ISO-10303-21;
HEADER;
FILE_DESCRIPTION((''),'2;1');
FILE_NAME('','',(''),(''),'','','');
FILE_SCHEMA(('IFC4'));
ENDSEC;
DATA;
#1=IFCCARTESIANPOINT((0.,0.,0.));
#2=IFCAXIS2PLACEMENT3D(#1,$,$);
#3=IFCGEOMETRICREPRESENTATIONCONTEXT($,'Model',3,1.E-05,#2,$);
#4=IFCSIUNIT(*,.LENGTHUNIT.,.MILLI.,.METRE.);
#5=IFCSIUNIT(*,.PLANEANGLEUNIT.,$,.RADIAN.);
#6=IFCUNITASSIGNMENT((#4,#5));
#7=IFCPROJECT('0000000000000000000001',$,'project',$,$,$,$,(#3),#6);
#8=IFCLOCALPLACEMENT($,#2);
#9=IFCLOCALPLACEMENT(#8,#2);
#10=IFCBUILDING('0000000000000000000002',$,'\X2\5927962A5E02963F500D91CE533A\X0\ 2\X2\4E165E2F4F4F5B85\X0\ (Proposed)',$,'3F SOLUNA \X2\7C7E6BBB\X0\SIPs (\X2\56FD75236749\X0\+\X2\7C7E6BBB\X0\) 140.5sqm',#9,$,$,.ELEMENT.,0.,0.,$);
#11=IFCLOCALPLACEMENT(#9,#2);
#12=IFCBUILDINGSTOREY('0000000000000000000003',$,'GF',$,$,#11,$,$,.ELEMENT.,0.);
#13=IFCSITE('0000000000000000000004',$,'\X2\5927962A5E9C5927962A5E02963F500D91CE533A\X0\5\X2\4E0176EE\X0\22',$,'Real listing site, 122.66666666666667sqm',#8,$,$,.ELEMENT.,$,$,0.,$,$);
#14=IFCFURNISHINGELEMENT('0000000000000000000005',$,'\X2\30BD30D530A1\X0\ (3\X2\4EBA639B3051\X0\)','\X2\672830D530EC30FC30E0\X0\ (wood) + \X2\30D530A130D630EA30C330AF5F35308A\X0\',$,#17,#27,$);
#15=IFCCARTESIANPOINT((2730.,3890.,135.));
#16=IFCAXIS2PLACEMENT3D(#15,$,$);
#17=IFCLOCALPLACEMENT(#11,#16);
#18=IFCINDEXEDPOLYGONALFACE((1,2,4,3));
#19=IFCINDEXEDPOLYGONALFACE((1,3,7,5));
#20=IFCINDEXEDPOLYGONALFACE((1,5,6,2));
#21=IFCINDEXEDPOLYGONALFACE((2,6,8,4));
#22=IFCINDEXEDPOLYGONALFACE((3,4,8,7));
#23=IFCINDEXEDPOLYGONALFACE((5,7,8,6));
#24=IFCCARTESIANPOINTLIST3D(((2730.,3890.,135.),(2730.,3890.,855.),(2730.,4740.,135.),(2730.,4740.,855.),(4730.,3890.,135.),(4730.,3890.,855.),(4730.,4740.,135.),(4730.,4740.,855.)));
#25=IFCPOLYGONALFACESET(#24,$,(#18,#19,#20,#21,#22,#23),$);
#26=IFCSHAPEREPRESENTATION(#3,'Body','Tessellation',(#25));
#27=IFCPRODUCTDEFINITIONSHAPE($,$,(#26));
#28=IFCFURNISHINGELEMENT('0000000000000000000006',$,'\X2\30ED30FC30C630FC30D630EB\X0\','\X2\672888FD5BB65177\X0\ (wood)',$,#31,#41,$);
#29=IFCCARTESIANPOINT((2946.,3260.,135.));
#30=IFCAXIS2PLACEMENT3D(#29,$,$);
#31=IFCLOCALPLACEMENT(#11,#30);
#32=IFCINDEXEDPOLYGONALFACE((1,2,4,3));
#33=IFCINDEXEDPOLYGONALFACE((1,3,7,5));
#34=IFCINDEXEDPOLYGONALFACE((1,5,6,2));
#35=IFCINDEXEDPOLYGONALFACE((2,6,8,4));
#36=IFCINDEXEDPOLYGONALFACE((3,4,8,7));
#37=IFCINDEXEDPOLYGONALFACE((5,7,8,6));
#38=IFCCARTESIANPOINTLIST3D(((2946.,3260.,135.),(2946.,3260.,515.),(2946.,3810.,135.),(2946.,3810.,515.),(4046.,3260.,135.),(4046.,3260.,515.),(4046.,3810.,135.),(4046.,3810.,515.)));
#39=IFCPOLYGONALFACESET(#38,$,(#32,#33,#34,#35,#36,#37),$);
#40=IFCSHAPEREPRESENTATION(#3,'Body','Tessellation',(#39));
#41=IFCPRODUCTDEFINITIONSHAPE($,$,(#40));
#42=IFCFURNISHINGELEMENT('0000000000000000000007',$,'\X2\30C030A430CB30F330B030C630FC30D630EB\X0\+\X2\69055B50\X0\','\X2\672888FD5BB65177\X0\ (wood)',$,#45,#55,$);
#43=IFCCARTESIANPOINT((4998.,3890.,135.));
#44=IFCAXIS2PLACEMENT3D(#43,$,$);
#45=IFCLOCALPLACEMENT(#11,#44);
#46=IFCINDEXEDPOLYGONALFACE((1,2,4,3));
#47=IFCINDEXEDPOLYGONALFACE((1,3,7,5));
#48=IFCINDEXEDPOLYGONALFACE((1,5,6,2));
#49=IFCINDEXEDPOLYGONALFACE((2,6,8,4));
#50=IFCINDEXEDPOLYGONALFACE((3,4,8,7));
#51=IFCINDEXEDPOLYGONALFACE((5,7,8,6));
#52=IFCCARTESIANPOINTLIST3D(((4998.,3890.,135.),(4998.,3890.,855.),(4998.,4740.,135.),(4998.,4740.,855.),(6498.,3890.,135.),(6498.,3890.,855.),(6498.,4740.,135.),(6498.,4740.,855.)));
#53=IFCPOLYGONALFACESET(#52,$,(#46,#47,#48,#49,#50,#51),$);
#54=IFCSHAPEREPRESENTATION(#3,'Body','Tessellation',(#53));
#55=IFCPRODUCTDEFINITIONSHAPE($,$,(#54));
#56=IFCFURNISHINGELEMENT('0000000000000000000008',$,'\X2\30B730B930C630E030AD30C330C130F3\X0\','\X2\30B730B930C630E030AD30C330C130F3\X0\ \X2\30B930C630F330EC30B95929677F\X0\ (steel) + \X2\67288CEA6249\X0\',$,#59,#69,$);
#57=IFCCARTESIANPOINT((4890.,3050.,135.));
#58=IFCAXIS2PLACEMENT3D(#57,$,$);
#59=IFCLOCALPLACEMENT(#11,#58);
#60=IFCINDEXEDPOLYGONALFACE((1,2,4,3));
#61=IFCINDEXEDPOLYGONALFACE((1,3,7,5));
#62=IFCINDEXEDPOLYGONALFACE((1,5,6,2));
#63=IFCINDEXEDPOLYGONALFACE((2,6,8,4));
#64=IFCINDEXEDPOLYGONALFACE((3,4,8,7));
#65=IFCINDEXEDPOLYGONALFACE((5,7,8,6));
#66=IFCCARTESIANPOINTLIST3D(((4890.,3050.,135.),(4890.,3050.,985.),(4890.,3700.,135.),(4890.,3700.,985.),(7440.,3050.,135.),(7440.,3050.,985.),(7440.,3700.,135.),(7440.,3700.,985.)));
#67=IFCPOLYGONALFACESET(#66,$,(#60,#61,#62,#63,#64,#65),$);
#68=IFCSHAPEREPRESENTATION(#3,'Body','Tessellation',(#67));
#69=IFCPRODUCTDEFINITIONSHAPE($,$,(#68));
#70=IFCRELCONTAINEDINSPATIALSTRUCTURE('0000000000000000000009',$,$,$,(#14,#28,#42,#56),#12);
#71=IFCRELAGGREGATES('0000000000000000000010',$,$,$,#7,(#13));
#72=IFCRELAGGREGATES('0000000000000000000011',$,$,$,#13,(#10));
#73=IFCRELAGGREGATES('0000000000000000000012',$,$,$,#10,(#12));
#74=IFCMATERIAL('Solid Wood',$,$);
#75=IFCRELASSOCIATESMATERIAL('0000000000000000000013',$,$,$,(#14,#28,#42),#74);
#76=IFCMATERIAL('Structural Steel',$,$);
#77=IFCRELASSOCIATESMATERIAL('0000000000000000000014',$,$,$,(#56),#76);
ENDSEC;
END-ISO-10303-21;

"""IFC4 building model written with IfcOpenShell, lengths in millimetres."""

from ifc_helpers import new_model, si_unit, frame, frame_2d, origin, place, context, project, spatial, rectangle, extrude, material, element, save


model = new_model("IFC4")

# Units and contexts
model_context = context("Model", 3, precision=1e-05, world=origin())
ifc_project = project(units=[si_unit("LENGTHUNIT", "METRE", prefix="MILLI"), si_unit("PLANEANGLEUNIT", "RADIAN")], contexts=[model_context])

# Site, building, storey
site_placement = place(None, origin())
site = spatial("IfcSite", under=ifc_project, at=site_placement, Name="大阪府大阪市阿倍野区5丁目22", ObjectType="Real listing site, 122.66666666666667sqm", CompositionType="ELEMENT", RefElevation=0.0)
building_placement = place(site_placement, origin())
building = spatial("IfcBuilding", under=site, at=building_placement, Name="大阪市阿倍野区 2世帯住宅 (Proposed)", ObjectType="3F SOLUNA 籾殻SIPs (国産杉+籾殻) 140.5sqm", CompositionType="ELEMENT", ElevationOfRefHeight=0.0, ElevationOfTerrain=0.0)
storey_placement = place(building_placement, origin())
storey = spatial("IfcBuildingStorey", under=building, at=storey_placement, Name="GF", CompositionType="ELEMENT", Elevation=0.0)

# Shared definitions
ifc_material_1 = material(Name="Solid Wood")

# Furnishing elements
furnishing_1_placement = place(storey_placement, frame((2730.0, 3890.0, 135.0)))
element("IfcFurnishingElement", 1, at=furnishing_1_placement, inside=storey, material=ifc_material_1, Name="ソファ (3人掛け)", Description="木フレーム (wood) + ファブリック張り", context=model_context, shape_type="SweptSolid", body=[
    extrude(rectangle(XDim=2000.0, YDim=850.0, at=frame_2d((1000.0, 425.0))), frame((2730.0, 3890.0, 135.0)), (0.0, 0.0, 1.0), 720.0),
])
furnishing_2_placement = place(storey_placement, frame((2946.0, 3260.0, 135.0)))
element("IfcFurnishingElement", 2, at=furnishing_2_placement, inside=storey, material=ifc_material_1, Name="ローテーブル", Description="木製家具 (wood)", context=model_context, shape_type="SweptSolid", body=[
    extrude(rectangle(XDim=1100.0, YDim=550.0, at=frame_2d((550.0, 275.0))), frame((2946.0, 3260.0, 135.0)), (0.0, 0.0, 1.0), 380.0),
])
furnishing_3_placement = place(storey_placement, frame((4998.0, 3890.0, 135.0)))
element("IfcFurnishingElement", 3, at=furnishing_3_placement, inside=storey, material=ifc_material_1, Name="ダイニングテーブル+椅子", Description="木製家具 (wood)", context=model_context, shape_type="SweptSolid", body=[
    extrude(rectangle(XDim=1500.0, YDim=850.0, at=frame_2d((750.0, 425.0))), frame((4998.0, 3890.0, 135.0)), (0.0, 0.0, 1.0), 720.0),
])
ifc_material_2 = material(Name="Structural Steel")
furnishing_4_placement = place(storey_placement, frame((4890.0, 3050.0, 135.0)))
element("IfcFurnishingElement", 4, at=furnishing_4_placement, inside=storey, material=ifc_material_2, Name="システムキッチン", Description="システムキッチン ステンレス天板 (steel) + 木質扉", context=model_context, shape_type="SweptSolid", body=[
    extrude(rectangle(XDim=2550.0, YDim=650.0, at=frame_2d((1275.0, 325.0))), frame((4890.0, 3050.0, 135.0)), (0.0, 0.0, 1.0), 850.0),
])

save(model, "model.ifc")
